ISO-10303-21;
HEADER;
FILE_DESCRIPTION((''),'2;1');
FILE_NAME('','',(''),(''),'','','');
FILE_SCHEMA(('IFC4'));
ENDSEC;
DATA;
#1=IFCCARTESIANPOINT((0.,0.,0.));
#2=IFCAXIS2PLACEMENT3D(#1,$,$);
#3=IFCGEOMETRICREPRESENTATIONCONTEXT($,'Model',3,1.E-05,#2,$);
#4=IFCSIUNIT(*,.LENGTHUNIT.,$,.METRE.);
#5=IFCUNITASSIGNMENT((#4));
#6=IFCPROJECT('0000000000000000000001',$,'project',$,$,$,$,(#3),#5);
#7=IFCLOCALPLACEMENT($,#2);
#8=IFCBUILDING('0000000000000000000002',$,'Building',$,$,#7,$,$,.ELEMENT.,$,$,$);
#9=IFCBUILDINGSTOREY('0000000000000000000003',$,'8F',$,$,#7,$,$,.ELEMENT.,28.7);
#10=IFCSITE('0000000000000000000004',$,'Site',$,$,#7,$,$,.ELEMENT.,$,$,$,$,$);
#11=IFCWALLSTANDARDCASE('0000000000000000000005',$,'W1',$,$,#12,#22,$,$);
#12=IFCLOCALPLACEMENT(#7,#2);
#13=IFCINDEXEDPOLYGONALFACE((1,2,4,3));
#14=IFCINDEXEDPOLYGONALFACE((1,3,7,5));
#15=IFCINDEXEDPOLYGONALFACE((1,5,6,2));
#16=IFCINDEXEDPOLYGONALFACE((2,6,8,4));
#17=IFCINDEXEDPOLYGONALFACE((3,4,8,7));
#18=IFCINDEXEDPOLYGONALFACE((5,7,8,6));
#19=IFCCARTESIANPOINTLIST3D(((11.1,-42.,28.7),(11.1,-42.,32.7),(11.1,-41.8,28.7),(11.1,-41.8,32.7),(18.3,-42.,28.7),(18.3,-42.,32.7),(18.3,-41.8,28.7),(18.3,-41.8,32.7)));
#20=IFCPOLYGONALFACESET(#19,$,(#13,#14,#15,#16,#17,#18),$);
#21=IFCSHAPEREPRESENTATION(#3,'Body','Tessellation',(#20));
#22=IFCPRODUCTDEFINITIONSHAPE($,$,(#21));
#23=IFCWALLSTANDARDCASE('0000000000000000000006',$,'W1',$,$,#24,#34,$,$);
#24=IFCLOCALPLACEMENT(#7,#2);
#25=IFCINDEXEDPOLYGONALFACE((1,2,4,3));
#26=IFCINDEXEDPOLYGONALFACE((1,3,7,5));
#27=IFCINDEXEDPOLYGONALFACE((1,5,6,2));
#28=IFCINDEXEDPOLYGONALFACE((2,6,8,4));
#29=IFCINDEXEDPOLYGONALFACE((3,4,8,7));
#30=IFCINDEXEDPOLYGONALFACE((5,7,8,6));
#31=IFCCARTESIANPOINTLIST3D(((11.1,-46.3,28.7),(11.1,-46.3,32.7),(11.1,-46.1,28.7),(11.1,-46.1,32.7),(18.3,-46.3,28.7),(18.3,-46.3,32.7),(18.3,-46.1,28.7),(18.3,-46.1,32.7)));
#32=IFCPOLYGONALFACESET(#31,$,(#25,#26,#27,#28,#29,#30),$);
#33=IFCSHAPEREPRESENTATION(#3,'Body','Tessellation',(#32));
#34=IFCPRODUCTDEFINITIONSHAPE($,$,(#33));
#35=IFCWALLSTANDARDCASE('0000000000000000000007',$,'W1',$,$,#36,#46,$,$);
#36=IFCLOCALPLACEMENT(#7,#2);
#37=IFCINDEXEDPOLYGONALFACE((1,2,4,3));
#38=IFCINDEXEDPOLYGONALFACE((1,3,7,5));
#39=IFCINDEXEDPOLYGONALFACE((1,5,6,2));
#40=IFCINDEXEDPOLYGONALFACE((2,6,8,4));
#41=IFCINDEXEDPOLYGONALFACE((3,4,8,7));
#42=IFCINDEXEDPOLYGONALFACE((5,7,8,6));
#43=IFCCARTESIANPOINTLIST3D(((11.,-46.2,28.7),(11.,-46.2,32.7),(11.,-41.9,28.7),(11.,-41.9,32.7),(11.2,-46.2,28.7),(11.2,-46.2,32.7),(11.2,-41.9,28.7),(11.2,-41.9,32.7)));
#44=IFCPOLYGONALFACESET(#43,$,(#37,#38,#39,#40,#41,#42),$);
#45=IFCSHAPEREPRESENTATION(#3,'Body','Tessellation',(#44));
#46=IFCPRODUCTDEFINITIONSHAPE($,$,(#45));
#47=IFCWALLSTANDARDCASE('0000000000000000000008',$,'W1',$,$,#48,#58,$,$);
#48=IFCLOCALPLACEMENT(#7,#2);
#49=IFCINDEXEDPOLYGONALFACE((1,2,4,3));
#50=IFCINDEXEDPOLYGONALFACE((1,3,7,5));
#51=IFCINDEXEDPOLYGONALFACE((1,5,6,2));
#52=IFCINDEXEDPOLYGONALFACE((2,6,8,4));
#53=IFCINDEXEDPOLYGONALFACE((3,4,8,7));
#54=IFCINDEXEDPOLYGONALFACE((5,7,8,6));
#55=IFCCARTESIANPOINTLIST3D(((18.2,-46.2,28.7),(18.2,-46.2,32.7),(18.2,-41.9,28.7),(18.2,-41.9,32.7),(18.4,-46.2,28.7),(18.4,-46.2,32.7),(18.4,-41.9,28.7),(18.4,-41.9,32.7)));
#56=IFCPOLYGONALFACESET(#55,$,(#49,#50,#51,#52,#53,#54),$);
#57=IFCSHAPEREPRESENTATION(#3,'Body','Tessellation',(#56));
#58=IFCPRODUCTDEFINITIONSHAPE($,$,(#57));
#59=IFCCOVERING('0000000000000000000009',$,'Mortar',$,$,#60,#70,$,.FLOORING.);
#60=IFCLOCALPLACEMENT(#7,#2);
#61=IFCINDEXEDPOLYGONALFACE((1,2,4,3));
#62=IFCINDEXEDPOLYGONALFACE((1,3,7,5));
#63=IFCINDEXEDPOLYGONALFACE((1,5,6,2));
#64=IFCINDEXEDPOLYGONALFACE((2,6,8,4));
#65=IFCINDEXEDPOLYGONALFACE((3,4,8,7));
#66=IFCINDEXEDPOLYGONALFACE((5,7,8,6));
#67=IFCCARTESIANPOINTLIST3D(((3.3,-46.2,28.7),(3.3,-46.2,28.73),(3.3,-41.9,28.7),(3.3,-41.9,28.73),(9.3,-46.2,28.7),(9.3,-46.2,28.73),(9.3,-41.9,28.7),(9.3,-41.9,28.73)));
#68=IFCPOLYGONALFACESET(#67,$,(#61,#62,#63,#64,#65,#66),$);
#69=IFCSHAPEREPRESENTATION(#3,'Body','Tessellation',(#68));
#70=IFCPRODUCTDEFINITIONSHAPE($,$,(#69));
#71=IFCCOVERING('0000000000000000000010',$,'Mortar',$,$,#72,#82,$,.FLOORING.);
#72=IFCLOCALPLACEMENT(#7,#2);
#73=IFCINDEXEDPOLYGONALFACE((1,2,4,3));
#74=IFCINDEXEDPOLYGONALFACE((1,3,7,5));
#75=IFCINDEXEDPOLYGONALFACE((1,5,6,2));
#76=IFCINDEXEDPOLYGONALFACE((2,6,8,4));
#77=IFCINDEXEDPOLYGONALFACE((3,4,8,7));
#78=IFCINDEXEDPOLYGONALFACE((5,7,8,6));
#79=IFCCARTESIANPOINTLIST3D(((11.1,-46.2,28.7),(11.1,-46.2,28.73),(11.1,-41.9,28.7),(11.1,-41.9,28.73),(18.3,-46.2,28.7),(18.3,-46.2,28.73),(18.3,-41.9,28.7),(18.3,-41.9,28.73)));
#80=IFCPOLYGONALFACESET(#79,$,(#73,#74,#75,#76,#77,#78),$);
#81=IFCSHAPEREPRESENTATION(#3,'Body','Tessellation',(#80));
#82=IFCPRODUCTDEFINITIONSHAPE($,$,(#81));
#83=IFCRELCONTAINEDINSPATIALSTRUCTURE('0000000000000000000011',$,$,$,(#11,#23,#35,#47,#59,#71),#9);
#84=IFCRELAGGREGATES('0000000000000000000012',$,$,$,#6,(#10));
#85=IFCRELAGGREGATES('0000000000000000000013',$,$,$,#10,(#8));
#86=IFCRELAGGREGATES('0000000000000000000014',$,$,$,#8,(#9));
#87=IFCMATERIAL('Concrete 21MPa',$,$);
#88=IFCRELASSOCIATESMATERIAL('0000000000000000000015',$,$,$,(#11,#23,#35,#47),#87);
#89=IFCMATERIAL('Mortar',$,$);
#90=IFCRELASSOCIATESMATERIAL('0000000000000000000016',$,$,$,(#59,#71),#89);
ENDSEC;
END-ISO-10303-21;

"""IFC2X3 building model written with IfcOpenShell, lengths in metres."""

from ifc_helpers import new_model, si_unit, frame, origin, origin_2d, place, context, project, spatial, rectangle, extrude, material, element, save


model = new_model("IFC2X3")

# Units and contexts
model_context = context("Model", 3, precision=1e-05, world=origin())
ifc_project = project(units=[si_unit("LENGTHUNIT", "METRE")], contexts=[model_context])

# Site, building, storey
placement = place(None, origin())
site = spatial("IfcSite", under=ifc_project, at=placement, Name="Site", CompositionType="ELEMENT")
building = spatial("IfcBuilding", under=site, at=placement, Name="Building", CompositionType="ELEMENT")
storey = spatial("IfcBuildingStorey", under=building, at=placement, Name="8F", CompositionType="ELEMENT", Elevation=28.7)

# Shared definitions
ifc_material_1 = material(Name="Concrete 21MPa")

# Walls
for number, where, name in (
    (1, (14.7, -41.9, 28.7), "W1"),
    (2, (14.7, -46.2, 28.7), "W1"),
):
    element("IfcWallStandardCase", number, at=place(None, frame(where)), inside=storey, material=ifc_material_1, Name=name, context=model_context, shape_type="SweptSolid", body=[
        extrude(rectangle(XDim=7.2, YDim=0.2, at=origin_2d()), origin(), (0.0, 0.0, 1.0), 4.0),
    ])
for number, where, name in (
    (3, (11.1, -44.05, 28.7), "W1"),
    (4, (18.3, -44.05, 28.7), "W1"),
):
    element("IfcWallStandardCase", number, at=place(None, frame(where)), inside=storey, material=ifc_material_1, Name=name, context=model_context, shape_type="SweptSolid", body=[
        extrude(rectangle(XDim=0.2, YDim=4.3, at=origin_2d()), origin(), (0.0, 0.0, 1.0), 4.0),
    ])

# Coverings
ifc_material_2 = material(Name="Mortar")
covering_1_placement = place(None, frame((6.3, -44.05, 28.7)))
element("IfcCovering", 5, at=covering_1_placement, inside=storey, material=ifc_material_2, Name="Mortar", PredefinedType="FLOORING", context=model_context, shape_type="SweptSolid", body=[
    extrude(rectangle(XDim=6.0, YDim=4.3, at=origin_2d()), origin(), (0.0, 0.0, 1.0), 0.03),
])
covering_2_placement = place(None, frame((14.7, -44.05, 28.7)))
element("IfcCovering", 6, at=covering_2_placement, inside=storey, material=ifc_material_2, Name="Mortar", PredefinedType="FLOORING", context=model_context, shape_type="SweptSolid", body=[
    extrude(rectangle(XDim=7.2, YDim=4.3, at=origin_2d()), origin(), (0.0, 0.0, 1.0), 0.03),
])

save(model, "model.ifc")
